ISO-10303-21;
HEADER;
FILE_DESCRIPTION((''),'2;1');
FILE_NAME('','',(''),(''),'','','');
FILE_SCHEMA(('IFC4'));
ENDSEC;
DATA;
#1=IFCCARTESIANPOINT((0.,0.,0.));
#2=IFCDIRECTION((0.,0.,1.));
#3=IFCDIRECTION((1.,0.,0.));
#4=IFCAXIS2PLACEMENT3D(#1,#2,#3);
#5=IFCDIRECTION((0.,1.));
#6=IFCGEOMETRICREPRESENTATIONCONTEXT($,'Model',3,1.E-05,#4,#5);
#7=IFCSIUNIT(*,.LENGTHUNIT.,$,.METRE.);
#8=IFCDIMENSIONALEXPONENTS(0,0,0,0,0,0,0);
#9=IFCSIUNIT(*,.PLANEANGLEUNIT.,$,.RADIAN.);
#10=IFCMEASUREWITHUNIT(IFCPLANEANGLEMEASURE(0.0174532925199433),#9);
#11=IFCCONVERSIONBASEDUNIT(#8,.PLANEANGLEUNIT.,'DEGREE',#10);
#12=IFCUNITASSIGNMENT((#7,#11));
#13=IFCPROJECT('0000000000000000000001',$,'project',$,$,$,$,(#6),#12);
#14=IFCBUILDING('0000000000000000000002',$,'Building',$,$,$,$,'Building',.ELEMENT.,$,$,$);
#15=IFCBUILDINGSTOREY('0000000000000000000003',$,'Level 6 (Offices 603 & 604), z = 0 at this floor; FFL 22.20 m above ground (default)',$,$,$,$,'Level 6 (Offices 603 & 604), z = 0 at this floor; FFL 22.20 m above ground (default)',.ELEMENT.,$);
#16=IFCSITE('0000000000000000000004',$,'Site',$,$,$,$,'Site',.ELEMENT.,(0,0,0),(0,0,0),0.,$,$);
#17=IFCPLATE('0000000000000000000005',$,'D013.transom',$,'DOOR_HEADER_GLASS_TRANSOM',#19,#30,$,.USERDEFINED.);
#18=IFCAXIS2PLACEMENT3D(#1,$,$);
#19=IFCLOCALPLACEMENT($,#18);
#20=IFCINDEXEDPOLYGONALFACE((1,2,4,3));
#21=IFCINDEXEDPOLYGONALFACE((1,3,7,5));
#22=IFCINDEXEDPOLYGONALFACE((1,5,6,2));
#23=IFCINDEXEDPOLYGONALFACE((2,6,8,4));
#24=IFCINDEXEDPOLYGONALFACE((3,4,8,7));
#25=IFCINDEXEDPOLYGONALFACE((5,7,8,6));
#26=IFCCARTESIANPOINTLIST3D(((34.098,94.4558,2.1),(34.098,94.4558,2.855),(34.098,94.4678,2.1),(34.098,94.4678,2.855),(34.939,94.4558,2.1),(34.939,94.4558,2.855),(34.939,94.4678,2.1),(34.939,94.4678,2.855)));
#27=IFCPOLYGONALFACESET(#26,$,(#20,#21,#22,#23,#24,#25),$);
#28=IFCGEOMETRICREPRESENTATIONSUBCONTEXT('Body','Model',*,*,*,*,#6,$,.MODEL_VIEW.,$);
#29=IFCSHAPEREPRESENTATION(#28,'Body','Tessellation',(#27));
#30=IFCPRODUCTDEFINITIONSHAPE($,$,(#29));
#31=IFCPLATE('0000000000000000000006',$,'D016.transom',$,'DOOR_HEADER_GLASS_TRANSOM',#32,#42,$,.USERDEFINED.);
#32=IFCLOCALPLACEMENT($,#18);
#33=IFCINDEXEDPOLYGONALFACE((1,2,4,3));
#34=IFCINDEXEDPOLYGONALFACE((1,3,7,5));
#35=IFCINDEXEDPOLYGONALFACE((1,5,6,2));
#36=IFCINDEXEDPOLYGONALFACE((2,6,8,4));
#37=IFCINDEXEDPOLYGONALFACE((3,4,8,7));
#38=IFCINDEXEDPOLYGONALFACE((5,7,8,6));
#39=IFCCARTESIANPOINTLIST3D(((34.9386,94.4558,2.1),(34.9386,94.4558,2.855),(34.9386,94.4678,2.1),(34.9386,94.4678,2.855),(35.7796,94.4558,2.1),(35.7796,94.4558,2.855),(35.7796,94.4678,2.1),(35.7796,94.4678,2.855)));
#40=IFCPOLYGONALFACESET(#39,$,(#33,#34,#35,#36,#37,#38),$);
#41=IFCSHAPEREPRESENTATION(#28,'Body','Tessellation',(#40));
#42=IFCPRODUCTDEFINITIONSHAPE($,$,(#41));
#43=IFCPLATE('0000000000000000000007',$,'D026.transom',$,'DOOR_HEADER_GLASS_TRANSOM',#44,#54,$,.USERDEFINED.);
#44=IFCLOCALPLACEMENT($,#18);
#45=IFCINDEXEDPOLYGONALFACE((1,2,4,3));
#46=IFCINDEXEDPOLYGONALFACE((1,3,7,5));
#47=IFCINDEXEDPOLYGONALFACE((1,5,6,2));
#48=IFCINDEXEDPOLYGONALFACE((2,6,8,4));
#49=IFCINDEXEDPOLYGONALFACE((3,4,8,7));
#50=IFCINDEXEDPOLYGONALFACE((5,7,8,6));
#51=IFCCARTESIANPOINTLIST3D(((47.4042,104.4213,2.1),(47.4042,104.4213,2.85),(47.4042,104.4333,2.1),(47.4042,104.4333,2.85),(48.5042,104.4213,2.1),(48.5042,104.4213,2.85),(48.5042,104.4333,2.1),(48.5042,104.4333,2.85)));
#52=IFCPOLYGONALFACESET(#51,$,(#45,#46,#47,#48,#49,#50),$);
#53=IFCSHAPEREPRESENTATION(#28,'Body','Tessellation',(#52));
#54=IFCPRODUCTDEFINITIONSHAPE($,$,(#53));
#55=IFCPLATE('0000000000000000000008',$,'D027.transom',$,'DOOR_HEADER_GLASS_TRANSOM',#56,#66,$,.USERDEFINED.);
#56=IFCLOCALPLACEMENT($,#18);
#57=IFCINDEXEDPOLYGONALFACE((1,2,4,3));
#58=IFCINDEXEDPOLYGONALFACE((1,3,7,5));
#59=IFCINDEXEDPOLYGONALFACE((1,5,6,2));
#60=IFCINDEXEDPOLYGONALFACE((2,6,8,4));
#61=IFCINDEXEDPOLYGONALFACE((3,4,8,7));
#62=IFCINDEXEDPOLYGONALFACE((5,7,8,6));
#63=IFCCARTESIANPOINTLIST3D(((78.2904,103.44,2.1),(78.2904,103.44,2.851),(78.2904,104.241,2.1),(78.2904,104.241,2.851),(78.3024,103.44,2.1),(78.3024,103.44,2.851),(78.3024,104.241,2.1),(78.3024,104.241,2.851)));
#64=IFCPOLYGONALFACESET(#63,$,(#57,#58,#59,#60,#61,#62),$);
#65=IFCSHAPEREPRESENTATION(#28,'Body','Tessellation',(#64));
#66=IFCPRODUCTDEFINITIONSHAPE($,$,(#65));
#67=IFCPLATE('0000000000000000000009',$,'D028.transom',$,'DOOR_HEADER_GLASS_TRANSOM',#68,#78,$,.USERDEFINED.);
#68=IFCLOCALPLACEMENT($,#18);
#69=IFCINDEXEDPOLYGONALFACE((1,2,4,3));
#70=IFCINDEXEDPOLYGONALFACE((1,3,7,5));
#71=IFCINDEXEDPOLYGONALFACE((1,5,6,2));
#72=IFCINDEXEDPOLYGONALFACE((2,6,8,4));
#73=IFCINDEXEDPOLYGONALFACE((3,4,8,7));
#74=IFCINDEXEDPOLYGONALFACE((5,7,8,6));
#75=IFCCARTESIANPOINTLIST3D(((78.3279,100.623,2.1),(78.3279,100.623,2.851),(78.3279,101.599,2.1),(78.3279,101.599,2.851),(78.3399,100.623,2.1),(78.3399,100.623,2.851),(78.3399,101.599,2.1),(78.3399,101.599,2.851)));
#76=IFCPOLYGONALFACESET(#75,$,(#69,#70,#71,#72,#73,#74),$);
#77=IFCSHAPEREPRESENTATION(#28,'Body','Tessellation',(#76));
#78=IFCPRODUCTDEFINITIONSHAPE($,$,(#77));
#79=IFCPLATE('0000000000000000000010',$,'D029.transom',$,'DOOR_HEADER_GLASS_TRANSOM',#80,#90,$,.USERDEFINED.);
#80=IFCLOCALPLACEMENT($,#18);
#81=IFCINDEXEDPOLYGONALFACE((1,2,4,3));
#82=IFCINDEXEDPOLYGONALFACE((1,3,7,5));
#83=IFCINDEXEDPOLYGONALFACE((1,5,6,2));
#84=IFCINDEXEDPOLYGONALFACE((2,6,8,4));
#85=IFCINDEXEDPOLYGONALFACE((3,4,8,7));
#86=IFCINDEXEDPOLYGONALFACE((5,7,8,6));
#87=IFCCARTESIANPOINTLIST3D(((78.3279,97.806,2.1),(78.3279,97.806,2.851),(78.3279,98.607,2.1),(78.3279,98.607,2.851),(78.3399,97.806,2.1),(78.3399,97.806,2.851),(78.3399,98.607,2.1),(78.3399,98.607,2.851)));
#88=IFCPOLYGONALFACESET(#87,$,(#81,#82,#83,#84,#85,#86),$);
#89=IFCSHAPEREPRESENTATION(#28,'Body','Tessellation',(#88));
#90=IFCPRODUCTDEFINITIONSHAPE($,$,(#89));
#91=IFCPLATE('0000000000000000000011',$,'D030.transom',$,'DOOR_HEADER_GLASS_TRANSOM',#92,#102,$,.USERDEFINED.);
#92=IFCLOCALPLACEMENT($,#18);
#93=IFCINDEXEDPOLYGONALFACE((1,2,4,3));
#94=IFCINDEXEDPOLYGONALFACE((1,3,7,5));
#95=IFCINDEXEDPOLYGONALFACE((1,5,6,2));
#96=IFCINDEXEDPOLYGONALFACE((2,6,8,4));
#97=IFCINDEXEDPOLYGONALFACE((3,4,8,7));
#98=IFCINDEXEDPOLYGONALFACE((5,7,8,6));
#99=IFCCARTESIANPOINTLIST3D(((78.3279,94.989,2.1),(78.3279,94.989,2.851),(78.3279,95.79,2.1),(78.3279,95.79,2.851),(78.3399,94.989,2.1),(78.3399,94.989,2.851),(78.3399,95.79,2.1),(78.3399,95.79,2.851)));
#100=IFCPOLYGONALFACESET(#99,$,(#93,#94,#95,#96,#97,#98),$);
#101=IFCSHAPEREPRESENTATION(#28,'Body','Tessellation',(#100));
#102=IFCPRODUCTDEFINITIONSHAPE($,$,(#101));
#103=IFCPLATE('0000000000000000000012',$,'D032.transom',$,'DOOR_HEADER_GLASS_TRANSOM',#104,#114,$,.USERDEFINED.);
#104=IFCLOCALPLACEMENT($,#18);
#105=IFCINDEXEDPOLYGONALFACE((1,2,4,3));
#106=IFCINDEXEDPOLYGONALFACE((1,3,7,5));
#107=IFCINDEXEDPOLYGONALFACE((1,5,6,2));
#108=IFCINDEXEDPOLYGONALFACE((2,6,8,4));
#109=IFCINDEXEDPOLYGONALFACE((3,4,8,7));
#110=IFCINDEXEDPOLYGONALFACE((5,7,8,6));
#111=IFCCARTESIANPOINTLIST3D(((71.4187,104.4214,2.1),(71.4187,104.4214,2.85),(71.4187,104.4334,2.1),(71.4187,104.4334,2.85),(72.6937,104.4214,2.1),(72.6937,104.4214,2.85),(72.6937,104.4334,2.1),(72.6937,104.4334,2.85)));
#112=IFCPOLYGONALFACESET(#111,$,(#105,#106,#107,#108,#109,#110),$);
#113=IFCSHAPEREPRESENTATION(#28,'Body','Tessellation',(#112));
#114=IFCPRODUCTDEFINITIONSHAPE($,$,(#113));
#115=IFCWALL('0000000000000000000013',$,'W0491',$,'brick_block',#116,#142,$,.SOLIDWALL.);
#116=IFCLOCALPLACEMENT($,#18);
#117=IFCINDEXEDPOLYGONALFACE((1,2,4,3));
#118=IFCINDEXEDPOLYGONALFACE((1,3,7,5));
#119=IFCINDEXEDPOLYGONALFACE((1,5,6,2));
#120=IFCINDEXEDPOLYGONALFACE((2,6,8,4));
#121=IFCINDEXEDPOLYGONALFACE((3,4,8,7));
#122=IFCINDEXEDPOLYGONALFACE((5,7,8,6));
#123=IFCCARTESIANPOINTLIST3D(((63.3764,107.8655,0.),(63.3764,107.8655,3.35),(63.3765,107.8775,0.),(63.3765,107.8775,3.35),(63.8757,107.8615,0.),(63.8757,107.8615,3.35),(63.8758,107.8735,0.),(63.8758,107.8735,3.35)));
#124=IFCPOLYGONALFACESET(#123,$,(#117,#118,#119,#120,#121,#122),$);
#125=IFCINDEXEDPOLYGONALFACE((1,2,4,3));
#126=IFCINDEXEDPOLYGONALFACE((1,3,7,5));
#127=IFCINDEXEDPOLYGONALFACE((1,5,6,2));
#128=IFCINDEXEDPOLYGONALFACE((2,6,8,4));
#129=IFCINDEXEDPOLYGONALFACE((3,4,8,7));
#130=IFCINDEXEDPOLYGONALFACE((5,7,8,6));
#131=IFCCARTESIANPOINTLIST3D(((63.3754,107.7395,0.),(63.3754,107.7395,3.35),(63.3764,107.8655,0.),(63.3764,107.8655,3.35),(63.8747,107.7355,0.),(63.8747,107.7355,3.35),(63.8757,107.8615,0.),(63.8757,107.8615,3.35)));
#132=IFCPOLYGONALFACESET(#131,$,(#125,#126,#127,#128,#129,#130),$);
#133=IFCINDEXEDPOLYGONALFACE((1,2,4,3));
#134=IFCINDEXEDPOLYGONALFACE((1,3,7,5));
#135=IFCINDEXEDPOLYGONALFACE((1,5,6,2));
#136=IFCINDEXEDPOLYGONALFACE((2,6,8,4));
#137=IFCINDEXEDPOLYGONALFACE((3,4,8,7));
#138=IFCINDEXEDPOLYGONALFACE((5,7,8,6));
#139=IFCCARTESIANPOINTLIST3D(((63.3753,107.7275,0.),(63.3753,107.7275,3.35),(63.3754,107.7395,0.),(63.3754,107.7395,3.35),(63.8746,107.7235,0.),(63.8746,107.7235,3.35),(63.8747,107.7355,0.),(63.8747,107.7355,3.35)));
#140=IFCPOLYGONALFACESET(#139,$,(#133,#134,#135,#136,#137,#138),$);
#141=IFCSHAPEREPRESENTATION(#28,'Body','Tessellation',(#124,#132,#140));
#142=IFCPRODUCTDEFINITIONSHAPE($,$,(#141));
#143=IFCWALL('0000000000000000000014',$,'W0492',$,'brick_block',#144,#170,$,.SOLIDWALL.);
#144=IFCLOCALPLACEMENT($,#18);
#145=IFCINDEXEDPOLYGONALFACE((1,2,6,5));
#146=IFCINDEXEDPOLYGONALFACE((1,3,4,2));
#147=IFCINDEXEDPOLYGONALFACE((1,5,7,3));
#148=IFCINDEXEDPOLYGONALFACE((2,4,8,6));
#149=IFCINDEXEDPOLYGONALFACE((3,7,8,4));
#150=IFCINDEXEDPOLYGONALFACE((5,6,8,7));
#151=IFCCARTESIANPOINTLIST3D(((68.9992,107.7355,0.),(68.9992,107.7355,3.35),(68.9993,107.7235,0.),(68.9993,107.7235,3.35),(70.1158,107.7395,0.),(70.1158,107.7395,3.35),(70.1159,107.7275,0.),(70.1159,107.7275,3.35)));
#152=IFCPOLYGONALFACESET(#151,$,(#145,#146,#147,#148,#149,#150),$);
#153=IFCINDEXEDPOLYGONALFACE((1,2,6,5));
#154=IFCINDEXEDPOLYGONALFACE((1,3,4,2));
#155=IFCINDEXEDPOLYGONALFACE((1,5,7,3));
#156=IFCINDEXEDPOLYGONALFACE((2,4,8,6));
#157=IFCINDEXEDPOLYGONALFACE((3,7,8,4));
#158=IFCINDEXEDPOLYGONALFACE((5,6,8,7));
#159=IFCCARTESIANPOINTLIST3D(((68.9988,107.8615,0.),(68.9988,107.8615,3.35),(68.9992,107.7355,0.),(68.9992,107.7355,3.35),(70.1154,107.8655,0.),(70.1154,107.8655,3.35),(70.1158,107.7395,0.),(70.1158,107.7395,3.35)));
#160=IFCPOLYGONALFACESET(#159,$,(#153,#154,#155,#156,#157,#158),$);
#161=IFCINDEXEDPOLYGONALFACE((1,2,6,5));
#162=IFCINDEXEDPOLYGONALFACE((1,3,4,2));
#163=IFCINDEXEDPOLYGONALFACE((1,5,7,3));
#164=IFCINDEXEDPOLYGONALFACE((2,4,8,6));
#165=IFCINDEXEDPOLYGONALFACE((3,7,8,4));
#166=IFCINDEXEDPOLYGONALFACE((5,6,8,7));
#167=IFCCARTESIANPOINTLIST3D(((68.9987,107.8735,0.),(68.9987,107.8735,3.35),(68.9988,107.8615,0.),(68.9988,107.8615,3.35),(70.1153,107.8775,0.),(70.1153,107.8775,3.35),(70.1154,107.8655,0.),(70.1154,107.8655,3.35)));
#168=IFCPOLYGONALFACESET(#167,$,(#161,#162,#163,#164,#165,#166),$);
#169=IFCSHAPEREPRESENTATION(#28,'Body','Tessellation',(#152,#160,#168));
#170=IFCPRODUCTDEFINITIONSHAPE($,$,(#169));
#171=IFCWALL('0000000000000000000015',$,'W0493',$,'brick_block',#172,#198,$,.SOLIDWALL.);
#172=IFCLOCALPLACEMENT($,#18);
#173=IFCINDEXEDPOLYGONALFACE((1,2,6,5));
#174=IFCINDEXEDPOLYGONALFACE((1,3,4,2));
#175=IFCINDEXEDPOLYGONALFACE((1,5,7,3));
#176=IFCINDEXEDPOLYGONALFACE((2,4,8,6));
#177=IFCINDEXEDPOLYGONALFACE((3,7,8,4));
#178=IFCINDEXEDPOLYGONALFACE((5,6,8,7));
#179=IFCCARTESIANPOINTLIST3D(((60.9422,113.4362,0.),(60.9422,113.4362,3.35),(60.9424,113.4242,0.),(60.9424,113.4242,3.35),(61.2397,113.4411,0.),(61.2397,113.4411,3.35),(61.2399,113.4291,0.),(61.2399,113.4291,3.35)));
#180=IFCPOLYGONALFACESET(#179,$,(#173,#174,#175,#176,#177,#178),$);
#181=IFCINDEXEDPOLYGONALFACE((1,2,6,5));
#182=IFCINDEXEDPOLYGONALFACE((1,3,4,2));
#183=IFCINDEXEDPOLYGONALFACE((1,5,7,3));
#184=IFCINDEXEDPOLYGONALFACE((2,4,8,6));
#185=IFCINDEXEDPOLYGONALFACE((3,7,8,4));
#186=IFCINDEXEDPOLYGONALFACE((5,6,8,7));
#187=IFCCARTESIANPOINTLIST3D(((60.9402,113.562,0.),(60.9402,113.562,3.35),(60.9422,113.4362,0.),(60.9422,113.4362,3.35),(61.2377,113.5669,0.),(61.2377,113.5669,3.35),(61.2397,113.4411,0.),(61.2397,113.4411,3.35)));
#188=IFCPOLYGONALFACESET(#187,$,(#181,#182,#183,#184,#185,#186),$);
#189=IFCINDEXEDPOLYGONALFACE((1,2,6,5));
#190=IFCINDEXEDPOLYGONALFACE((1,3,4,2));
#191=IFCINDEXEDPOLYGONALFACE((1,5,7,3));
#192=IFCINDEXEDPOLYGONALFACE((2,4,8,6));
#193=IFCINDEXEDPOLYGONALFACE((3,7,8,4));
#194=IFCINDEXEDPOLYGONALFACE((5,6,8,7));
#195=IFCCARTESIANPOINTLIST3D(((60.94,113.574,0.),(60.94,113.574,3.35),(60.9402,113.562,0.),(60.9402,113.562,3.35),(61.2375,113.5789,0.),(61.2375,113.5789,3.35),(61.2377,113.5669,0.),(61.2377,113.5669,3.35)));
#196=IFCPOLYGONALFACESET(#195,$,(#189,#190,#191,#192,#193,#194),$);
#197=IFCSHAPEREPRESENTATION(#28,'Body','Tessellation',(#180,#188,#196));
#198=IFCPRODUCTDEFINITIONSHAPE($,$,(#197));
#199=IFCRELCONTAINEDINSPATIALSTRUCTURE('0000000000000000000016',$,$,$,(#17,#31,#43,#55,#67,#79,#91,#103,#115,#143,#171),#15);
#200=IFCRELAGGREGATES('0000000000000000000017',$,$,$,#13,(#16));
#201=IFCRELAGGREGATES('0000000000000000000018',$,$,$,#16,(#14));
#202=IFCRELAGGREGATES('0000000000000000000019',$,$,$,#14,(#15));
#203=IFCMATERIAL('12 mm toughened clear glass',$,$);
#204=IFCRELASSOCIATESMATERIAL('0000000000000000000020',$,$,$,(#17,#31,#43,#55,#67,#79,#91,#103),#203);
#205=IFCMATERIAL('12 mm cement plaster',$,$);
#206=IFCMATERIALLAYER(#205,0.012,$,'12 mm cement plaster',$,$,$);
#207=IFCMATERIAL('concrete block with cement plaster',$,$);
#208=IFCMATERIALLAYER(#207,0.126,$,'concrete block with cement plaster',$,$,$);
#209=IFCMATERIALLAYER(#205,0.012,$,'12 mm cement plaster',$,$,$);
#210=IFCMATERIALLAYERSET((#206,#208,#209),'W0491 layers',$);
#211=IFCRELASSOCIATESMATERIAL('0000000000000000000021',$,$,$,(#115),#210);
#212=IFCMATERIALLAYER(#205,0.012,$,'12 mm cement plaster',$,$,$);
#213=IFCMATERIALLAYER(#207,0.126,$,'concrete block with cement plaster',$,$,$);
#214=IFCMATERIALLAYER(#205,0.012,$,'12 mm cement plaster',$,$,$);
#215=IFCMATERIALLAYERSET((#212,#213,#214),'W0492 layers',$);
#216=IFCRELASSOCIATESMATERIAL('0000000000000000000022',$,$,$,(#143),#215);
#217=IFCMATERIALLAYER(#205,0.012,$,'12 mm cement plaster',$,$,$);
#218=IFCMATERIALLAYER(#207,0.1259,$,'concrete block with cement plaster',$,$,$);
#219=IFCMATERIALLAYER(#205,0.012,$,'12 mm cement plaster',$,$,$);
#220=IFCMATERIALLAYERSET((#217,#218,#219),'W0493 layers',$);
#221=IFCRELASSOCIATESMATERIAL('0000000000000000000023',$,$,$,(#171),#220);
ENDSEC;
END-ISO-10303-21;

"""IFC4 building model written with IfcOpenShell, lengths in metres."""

from ifc_helpers import new_model, entity, si_unit, converted_unit, direction, frame, frame_2d, origin_with_axes, place, context, subcontext, project, spatial, rectangle, extrude, material, layer, layer_set, layer_usage, element, save


model = new_model("IFC4")

# Units and contexts
model_context = context("Model", 3, precision=1e-05, world=origin_with_axes(), true_north=direction((0.0, 1.0)))
body_context = subcontext(model_context, "Body", "Model", "MODEL_VIEW")
ifc_project = project(units=[si_unit("LENGTHUNIT", "METRE"), converted_unit("PLANEANGLEUNIT", "DEGREE", entity("IfcPlaneAngleMeasure", 0.0174532925199433), si_unit("PLANEANGLEUNIT", "RADIAN"), dimensions=[0, 0, 0, 0, 0, 0, 0])], contexts=[model_context])

# Site, building, storey
site = spatial("IfcSite", under=ifc_project, Name="Site", LongName="Site", CompositionType="ELEMENT", RefLatitude=(0, 0, 0), RefLongitude=(0, 0, 0), RefElevation=0.0)
building = spatial("IfcBuilding", under=site, Name="Building", LongName="Building", CompositionType="ELEMENT")
storey = spatial("IfcBuildingStorey", under=building, Name="Level 6 (Offices 603 & 604), z = 0 at this floor; FFL 22.20 m above ground (default)", LongName="Level 6 (Offices 603 & 604), z = 0 at this floor; FFL 22.20 m above ground (default)", CompositionType="ELEMENT")

# Plates
ifc_material_1 = material(Name="12 mm toughened clear glass")
placement = place(None, origin_with_axes())
element("IfcPlate", 1, at=placement, inside=storey, material=ifc_material_1, Name="D013.transom", ObjectType="DOOR_HEADER_GLASS_TRANSOM", PredefinedType="USERDEFINED", context=body_context, shape_type="SweptSolid", body=[
    extrude(rectangle(XDim=0.841, YDim=0.012, at=frame_2d((0.0, 0.0), x_axis=(1.0, 0.0))), frame((34.5185, 94.4618, 2.1), z_axis=(0.0, 0.0, 1.0), x_axis=(1.0, 0.0, 0.0)), (0.0, 0.0, 1.0), 0.755),
])
element("IfcPlate", 2, at=placement, inside=storey, material=ifc_material_1, Name="D016.transom", ObjectType="DOOR_HEADER_GLASS_TRANSOM", PredefinedType="USERDEFINED", context=body_context, shape_type="SweptSolid", body=[
    extrude(rectangle(XDim=0.841, YDim=0.012, at=frame_2d((0.0, 0.0), x_axis=(1.0, 0.0))), frame((35.3591, 94.4618, 2.1), z_axis=(0.0, 0.0, 1.0), x_axis=(1.0, 0.0, 0.0)), (0.0, 0.0, 1.0), 0.755),
])
element("IfcPlate", 3, at=placement, inside=storey, material=ifc_material_1, Name="D026.transom", ObjectType="DOOR_HEADER_GLASS_TRANSOM", PredefinedType="USERDEFINED", context=body_context, shape_type="SweptSolid", body=[
    extrude(rectangle(XDim=1.1, YDim=0.012, at=frame_2d((0.0, 0.0), x_axis=(1.0, 0.0))), frame((47.9542, 104.4273, 2.1), z_axis=(0.0, 0.0, 1.0), x_axis=(1.0, 0.0, 0.0)), (0.0, 0.0, 1.0), 0.75),
])
element("IfcPlate", 4, at=placement, inside=storey, material=ifc_material_1, Name="D027.transom", ObjectType="DOOR_HEADER_GLASS_TRANSOM", PredefinedType="USERDEFINED", context=body_context, shape_type="SweptSolid", body=[
    extrude(rectangle(XDim=0.801, YDim=0.012, at=frame_2d((0.0, 0.0), x_axis=(0.0, 1.0))), frame((78.2964, 103.8405, 2.1), z_axis=(0.0, 0.0, 1.0), x_axis=(1.0, 0.0, 0.0)), (0.0, 0.0, 1.0), 0.751),
])
element("IfcPlate", 5, at=placement, inside=storey, material=ifc_material_1, Name="D028.transom", ObjectType="DOOR_HEADER_GLASS_TRANSOM", PredefinedType="USERDEFINED", context=body_context, shape_type="SweptSolid", body=[
    extrude(rectangle(XDim=0.976, YDim=0.012, at=frame_2d((0.0, 0.0), x_axis=(0.0, 1.0))), frame((78.3339, 101.111, 2.1), z_axis=(0.0, 0.0, 1.0), x_axis=(1.0, 0.0, 0.0)), (0.0, 0.0, 1.0), 0.751),
])
element("IfcPlate", 6, at=placement, inside=storey, material=ifc_material_1, Name="D029.transom", ObjectType="DOOR_HEADER_GLASS_TRANSOM", PredefinedType="USERDEFINED", context=body_context, shape_type="SweptSolid", body=[
    extrude(rectangle(XDim=0.801, YDim=0.012, at=frame_2d((0.0, 0.0), x_axis=(0.0, 1.0))), frame((78.3339, 98.2065, 2.1), z_axis=(0.0, 0.0, 1.0), x_axis=(1.0, 0.0, 0.0)), (0.0, 0.0, 1.0), 0.751),
])
element("IfcPlate", 7, at=placement, inside=storey, material=ifc_material_1, Name="D030.transom", ObjectType="DOOR_HEADER_GLASS_TRANSOM", PredefinedType="USERDEFINED", context=body_context, shape_type="SweptSolid", body=[
    extrude(rectangle(XDim=0.801, YDim=0.012, at=frame_2d((0.0, 0.0), x_axis=(0.0, 1.0))), frame((78.3339, 95.3895, 2.1), z_axis=(0.0, 0.0, 1.0), x_axis=(1.0, 0.0, 0.0)), (0.0, 0.0, 1.0), 0.751),
])
element("IfcPlate", 8, at=placement, inside=storey, material=ifc_material_1, Name="D032.transom", ObjectType="DOOR_HEADER_GLASS_TRANSOM", PredefinedType="USERDEFINED", context=body_context, shape_type="SweptSolid", body=[
    extrude(rectangle(XDim=1.275, YDim=0.012, at=frame_2d((0.0, 0.0), x_axis=(1.0, 0.0))), frame((72.0562, 104.4274, 2.1), z_axis=(0.0, 0.0, 1.0), x_axis=(1.0, 0.0, 0.0)), (0.0, 0.0, 1.0), 0.75),
])

# Walls
ifc_material_2 = material(Name="12 mm cement plaster")
ifc_layer_1 = layer(ifc_material_2, 0.012, Name="12 mm cement plaster")
ifc_material_3 = material(Name="concrete block with cement plaster")
ifc_layer_2 = layer(ifc_material_3, 0.126, Name="concrete block with cement plaster")
ifc_layer_3 = layer(ifc_material_2, 0.012, Name="12 mm cement plaster")
ifc_layer_set_1 = layer_set([ifc_layer_1, ifc_layer_2, ifc_layer_3], Name="W0491 layers")
ifc_layer_usage_1 = layer_usage(ifc_layer_set_1, "AXIS2", "POSITIVE", -0.075)
element("IfcWall", 9, at=placement, inside=storey, material=ifc_layer_usage_1, Name="W0491", ObjectType="brick_block", PredefinedType="SOLIDWALL", context=body_context, shape_type="SweptSolid", body=[
    extrude(rectangle(XDim=0.4993, YDim=0.012, at=frame_2d((0.0, 0.0), x_axis=(0.999968, -0.008011))), frame((63.6261, 107.8695, 0.0), z_axis=(0.0, 0.0, 1.0), x_axis=(1.0, 0.0, 0.0)), (0.0, 0.0, 1.0), 3.35),
    extrude(rectangle(XDim=0.4993, YDim=0.126, at=frame_2d((-0.0006, -0.069), x_axis=(0.999968, -0.008011))), frame((63.6261, 107.8695, 0.0), z_axis=(0.0, 0.0, 1.0), x_axis=(1.0, 0.0, 0.0)), (0.0, 0.0, 1.0), 3.35),
    extrude(rectangle(XDim=0.4993, YDim=0.012, at=frame_2d((-0.0011, -0.138), x_axis=(0.999968, -0.008011))), frame((63.6261, 107.8695, 0.0), z_axis=(0.0, 0.0, 1.0), x_axis=(1.0, 0.0, 0.0)), (0.0, 0.0, 1.0), 3.35),
])
ifc_layer_4 = layer(ifc_material_2, 0.012, Name="12 mm cement plaster")
ifc_layer_5 = layer(ifc_material_3, 0.126, Name="concrete block with cement plaster")
ifc_layer_6 = layer(ifc_material_2, 0.012, Name="12 mm cement plaster")
ifc_layer_set_2 = layer_set([ifc_layer_4, ifc_layer_5, ifc_layer_6], Name="W0492 layers")
ifc_layer_usage_2 = layer_usage(ifc_layer_set_2, "AXIS2", "POSITIVE", -0.075)
element("IfcWall", 10, at=placement, inside=storey, material=ifc_layer_usage_2, Name="W0492", ObjectType="brick_block", PredefinedType="SOLIDWALL", context=body_context, shape_type="SweptSolid", body=[
    extrude(rectangle(XDim=1.1166, YDim=0.012, at=frame_2d((0.0, 0.0), x_axis=(0.999994, 0.003582))), frame((69.5575, 107.7315, 0.0), z_axis=(0.0, 0.0, 1.0), x_axis=(1.0, 0.0, 0.0)), (0.0, 0.0, 1.0), 3.35),
    extrude(rectangle(XDim=1.1166, YDim=0.126, at=frame_2d((-0.0002, 0.069), x_axis=(0.999994, 0.003582))), frame((69.5575, 107.7315, 0.0), z_axis=(0.0, 0.0, 1.0), x_axis=(1.0, 0.0, 0.0)), (0.0, 0.0, 1.0), 3.35),
    extrude(rectangle(XDim=1.1166, YDim=0.012, at=frame_2d((-0.0005, 0.138), x_axis=(0.999994, 0.003582))), frame((69.5575, 107.7315, 0.0), z_axis=(0.0, 0.0, 1.0), x_axis=(1.0, 0.0, 0.0)), (0.0, 0.0, 1.0), 3.35),
])
ifc_layer_7 = layer(ifc_material_2, 0.012, Name="12 mm cement plaster")
ifc_layer_8 = layer(ifc_material_3, 0.1259, Name="concrete block with cement plaster")
ifc_layer_9 = layer(ifc_material_2, 0.012, Name="12 mm cement plaster")
ifc_layer_set_3 = layer_set([ifc_layer_7, ifc_layer_8, ifc_layer_9], Name="W0493 layers")
ifc_layer_usage_3 = layer_usage(ifc_layer_set_3, "AXIS2", "POSITIVE", -0.075)
element("IfcWall", 11, at=placement, inside=storey, material=ifc_layer_usage_3, Name="W0493", ObjectType="brick_block", PredefinedType="SOLIDWALL", context=body_context, shape_type="SweptSolid", body=[
    extrude(rectangle(XDim=0.2975, YDim=0.012, at=frame_2d((0.0, 0.0), x_axis=(0.999864, 0.016468))), frame((61.0911, 113.4326, 0.0), z_axis=(0.0, 0.0, 1.0), x_axis=(1.0, 0.0, 0.0)), (0.0, 0.0, 1.0), 3.35),
    extrude(rectangle(XDim=0.2975, YDim=0.1259, at=frame_2d((-0.0011, 0.0689), x_axis=(0.999864, 0.016468))), frame((61.0911, 113.4326, 0.0), z_axis=(0.0, 0.0, 1.0), x_axis=(1.0, 0.0, 0.0)), (0.0, 0.0, 1.0), 3.35),
    extrude(rectangle(XDim=0.2975, YDim=0.012, at=frame_2d((-0.0023, 0.1379), x_axis=(0.999864, 0.016468))), frame((61.0911, 113.4326, 0.0), z_axis=(0.0, 0.0, 1.0), x_axis=(1.0, 0.0, 0.0)), (0.0, 0.0, 1.0), 3.35),
])

save(model, "model.ifc")
